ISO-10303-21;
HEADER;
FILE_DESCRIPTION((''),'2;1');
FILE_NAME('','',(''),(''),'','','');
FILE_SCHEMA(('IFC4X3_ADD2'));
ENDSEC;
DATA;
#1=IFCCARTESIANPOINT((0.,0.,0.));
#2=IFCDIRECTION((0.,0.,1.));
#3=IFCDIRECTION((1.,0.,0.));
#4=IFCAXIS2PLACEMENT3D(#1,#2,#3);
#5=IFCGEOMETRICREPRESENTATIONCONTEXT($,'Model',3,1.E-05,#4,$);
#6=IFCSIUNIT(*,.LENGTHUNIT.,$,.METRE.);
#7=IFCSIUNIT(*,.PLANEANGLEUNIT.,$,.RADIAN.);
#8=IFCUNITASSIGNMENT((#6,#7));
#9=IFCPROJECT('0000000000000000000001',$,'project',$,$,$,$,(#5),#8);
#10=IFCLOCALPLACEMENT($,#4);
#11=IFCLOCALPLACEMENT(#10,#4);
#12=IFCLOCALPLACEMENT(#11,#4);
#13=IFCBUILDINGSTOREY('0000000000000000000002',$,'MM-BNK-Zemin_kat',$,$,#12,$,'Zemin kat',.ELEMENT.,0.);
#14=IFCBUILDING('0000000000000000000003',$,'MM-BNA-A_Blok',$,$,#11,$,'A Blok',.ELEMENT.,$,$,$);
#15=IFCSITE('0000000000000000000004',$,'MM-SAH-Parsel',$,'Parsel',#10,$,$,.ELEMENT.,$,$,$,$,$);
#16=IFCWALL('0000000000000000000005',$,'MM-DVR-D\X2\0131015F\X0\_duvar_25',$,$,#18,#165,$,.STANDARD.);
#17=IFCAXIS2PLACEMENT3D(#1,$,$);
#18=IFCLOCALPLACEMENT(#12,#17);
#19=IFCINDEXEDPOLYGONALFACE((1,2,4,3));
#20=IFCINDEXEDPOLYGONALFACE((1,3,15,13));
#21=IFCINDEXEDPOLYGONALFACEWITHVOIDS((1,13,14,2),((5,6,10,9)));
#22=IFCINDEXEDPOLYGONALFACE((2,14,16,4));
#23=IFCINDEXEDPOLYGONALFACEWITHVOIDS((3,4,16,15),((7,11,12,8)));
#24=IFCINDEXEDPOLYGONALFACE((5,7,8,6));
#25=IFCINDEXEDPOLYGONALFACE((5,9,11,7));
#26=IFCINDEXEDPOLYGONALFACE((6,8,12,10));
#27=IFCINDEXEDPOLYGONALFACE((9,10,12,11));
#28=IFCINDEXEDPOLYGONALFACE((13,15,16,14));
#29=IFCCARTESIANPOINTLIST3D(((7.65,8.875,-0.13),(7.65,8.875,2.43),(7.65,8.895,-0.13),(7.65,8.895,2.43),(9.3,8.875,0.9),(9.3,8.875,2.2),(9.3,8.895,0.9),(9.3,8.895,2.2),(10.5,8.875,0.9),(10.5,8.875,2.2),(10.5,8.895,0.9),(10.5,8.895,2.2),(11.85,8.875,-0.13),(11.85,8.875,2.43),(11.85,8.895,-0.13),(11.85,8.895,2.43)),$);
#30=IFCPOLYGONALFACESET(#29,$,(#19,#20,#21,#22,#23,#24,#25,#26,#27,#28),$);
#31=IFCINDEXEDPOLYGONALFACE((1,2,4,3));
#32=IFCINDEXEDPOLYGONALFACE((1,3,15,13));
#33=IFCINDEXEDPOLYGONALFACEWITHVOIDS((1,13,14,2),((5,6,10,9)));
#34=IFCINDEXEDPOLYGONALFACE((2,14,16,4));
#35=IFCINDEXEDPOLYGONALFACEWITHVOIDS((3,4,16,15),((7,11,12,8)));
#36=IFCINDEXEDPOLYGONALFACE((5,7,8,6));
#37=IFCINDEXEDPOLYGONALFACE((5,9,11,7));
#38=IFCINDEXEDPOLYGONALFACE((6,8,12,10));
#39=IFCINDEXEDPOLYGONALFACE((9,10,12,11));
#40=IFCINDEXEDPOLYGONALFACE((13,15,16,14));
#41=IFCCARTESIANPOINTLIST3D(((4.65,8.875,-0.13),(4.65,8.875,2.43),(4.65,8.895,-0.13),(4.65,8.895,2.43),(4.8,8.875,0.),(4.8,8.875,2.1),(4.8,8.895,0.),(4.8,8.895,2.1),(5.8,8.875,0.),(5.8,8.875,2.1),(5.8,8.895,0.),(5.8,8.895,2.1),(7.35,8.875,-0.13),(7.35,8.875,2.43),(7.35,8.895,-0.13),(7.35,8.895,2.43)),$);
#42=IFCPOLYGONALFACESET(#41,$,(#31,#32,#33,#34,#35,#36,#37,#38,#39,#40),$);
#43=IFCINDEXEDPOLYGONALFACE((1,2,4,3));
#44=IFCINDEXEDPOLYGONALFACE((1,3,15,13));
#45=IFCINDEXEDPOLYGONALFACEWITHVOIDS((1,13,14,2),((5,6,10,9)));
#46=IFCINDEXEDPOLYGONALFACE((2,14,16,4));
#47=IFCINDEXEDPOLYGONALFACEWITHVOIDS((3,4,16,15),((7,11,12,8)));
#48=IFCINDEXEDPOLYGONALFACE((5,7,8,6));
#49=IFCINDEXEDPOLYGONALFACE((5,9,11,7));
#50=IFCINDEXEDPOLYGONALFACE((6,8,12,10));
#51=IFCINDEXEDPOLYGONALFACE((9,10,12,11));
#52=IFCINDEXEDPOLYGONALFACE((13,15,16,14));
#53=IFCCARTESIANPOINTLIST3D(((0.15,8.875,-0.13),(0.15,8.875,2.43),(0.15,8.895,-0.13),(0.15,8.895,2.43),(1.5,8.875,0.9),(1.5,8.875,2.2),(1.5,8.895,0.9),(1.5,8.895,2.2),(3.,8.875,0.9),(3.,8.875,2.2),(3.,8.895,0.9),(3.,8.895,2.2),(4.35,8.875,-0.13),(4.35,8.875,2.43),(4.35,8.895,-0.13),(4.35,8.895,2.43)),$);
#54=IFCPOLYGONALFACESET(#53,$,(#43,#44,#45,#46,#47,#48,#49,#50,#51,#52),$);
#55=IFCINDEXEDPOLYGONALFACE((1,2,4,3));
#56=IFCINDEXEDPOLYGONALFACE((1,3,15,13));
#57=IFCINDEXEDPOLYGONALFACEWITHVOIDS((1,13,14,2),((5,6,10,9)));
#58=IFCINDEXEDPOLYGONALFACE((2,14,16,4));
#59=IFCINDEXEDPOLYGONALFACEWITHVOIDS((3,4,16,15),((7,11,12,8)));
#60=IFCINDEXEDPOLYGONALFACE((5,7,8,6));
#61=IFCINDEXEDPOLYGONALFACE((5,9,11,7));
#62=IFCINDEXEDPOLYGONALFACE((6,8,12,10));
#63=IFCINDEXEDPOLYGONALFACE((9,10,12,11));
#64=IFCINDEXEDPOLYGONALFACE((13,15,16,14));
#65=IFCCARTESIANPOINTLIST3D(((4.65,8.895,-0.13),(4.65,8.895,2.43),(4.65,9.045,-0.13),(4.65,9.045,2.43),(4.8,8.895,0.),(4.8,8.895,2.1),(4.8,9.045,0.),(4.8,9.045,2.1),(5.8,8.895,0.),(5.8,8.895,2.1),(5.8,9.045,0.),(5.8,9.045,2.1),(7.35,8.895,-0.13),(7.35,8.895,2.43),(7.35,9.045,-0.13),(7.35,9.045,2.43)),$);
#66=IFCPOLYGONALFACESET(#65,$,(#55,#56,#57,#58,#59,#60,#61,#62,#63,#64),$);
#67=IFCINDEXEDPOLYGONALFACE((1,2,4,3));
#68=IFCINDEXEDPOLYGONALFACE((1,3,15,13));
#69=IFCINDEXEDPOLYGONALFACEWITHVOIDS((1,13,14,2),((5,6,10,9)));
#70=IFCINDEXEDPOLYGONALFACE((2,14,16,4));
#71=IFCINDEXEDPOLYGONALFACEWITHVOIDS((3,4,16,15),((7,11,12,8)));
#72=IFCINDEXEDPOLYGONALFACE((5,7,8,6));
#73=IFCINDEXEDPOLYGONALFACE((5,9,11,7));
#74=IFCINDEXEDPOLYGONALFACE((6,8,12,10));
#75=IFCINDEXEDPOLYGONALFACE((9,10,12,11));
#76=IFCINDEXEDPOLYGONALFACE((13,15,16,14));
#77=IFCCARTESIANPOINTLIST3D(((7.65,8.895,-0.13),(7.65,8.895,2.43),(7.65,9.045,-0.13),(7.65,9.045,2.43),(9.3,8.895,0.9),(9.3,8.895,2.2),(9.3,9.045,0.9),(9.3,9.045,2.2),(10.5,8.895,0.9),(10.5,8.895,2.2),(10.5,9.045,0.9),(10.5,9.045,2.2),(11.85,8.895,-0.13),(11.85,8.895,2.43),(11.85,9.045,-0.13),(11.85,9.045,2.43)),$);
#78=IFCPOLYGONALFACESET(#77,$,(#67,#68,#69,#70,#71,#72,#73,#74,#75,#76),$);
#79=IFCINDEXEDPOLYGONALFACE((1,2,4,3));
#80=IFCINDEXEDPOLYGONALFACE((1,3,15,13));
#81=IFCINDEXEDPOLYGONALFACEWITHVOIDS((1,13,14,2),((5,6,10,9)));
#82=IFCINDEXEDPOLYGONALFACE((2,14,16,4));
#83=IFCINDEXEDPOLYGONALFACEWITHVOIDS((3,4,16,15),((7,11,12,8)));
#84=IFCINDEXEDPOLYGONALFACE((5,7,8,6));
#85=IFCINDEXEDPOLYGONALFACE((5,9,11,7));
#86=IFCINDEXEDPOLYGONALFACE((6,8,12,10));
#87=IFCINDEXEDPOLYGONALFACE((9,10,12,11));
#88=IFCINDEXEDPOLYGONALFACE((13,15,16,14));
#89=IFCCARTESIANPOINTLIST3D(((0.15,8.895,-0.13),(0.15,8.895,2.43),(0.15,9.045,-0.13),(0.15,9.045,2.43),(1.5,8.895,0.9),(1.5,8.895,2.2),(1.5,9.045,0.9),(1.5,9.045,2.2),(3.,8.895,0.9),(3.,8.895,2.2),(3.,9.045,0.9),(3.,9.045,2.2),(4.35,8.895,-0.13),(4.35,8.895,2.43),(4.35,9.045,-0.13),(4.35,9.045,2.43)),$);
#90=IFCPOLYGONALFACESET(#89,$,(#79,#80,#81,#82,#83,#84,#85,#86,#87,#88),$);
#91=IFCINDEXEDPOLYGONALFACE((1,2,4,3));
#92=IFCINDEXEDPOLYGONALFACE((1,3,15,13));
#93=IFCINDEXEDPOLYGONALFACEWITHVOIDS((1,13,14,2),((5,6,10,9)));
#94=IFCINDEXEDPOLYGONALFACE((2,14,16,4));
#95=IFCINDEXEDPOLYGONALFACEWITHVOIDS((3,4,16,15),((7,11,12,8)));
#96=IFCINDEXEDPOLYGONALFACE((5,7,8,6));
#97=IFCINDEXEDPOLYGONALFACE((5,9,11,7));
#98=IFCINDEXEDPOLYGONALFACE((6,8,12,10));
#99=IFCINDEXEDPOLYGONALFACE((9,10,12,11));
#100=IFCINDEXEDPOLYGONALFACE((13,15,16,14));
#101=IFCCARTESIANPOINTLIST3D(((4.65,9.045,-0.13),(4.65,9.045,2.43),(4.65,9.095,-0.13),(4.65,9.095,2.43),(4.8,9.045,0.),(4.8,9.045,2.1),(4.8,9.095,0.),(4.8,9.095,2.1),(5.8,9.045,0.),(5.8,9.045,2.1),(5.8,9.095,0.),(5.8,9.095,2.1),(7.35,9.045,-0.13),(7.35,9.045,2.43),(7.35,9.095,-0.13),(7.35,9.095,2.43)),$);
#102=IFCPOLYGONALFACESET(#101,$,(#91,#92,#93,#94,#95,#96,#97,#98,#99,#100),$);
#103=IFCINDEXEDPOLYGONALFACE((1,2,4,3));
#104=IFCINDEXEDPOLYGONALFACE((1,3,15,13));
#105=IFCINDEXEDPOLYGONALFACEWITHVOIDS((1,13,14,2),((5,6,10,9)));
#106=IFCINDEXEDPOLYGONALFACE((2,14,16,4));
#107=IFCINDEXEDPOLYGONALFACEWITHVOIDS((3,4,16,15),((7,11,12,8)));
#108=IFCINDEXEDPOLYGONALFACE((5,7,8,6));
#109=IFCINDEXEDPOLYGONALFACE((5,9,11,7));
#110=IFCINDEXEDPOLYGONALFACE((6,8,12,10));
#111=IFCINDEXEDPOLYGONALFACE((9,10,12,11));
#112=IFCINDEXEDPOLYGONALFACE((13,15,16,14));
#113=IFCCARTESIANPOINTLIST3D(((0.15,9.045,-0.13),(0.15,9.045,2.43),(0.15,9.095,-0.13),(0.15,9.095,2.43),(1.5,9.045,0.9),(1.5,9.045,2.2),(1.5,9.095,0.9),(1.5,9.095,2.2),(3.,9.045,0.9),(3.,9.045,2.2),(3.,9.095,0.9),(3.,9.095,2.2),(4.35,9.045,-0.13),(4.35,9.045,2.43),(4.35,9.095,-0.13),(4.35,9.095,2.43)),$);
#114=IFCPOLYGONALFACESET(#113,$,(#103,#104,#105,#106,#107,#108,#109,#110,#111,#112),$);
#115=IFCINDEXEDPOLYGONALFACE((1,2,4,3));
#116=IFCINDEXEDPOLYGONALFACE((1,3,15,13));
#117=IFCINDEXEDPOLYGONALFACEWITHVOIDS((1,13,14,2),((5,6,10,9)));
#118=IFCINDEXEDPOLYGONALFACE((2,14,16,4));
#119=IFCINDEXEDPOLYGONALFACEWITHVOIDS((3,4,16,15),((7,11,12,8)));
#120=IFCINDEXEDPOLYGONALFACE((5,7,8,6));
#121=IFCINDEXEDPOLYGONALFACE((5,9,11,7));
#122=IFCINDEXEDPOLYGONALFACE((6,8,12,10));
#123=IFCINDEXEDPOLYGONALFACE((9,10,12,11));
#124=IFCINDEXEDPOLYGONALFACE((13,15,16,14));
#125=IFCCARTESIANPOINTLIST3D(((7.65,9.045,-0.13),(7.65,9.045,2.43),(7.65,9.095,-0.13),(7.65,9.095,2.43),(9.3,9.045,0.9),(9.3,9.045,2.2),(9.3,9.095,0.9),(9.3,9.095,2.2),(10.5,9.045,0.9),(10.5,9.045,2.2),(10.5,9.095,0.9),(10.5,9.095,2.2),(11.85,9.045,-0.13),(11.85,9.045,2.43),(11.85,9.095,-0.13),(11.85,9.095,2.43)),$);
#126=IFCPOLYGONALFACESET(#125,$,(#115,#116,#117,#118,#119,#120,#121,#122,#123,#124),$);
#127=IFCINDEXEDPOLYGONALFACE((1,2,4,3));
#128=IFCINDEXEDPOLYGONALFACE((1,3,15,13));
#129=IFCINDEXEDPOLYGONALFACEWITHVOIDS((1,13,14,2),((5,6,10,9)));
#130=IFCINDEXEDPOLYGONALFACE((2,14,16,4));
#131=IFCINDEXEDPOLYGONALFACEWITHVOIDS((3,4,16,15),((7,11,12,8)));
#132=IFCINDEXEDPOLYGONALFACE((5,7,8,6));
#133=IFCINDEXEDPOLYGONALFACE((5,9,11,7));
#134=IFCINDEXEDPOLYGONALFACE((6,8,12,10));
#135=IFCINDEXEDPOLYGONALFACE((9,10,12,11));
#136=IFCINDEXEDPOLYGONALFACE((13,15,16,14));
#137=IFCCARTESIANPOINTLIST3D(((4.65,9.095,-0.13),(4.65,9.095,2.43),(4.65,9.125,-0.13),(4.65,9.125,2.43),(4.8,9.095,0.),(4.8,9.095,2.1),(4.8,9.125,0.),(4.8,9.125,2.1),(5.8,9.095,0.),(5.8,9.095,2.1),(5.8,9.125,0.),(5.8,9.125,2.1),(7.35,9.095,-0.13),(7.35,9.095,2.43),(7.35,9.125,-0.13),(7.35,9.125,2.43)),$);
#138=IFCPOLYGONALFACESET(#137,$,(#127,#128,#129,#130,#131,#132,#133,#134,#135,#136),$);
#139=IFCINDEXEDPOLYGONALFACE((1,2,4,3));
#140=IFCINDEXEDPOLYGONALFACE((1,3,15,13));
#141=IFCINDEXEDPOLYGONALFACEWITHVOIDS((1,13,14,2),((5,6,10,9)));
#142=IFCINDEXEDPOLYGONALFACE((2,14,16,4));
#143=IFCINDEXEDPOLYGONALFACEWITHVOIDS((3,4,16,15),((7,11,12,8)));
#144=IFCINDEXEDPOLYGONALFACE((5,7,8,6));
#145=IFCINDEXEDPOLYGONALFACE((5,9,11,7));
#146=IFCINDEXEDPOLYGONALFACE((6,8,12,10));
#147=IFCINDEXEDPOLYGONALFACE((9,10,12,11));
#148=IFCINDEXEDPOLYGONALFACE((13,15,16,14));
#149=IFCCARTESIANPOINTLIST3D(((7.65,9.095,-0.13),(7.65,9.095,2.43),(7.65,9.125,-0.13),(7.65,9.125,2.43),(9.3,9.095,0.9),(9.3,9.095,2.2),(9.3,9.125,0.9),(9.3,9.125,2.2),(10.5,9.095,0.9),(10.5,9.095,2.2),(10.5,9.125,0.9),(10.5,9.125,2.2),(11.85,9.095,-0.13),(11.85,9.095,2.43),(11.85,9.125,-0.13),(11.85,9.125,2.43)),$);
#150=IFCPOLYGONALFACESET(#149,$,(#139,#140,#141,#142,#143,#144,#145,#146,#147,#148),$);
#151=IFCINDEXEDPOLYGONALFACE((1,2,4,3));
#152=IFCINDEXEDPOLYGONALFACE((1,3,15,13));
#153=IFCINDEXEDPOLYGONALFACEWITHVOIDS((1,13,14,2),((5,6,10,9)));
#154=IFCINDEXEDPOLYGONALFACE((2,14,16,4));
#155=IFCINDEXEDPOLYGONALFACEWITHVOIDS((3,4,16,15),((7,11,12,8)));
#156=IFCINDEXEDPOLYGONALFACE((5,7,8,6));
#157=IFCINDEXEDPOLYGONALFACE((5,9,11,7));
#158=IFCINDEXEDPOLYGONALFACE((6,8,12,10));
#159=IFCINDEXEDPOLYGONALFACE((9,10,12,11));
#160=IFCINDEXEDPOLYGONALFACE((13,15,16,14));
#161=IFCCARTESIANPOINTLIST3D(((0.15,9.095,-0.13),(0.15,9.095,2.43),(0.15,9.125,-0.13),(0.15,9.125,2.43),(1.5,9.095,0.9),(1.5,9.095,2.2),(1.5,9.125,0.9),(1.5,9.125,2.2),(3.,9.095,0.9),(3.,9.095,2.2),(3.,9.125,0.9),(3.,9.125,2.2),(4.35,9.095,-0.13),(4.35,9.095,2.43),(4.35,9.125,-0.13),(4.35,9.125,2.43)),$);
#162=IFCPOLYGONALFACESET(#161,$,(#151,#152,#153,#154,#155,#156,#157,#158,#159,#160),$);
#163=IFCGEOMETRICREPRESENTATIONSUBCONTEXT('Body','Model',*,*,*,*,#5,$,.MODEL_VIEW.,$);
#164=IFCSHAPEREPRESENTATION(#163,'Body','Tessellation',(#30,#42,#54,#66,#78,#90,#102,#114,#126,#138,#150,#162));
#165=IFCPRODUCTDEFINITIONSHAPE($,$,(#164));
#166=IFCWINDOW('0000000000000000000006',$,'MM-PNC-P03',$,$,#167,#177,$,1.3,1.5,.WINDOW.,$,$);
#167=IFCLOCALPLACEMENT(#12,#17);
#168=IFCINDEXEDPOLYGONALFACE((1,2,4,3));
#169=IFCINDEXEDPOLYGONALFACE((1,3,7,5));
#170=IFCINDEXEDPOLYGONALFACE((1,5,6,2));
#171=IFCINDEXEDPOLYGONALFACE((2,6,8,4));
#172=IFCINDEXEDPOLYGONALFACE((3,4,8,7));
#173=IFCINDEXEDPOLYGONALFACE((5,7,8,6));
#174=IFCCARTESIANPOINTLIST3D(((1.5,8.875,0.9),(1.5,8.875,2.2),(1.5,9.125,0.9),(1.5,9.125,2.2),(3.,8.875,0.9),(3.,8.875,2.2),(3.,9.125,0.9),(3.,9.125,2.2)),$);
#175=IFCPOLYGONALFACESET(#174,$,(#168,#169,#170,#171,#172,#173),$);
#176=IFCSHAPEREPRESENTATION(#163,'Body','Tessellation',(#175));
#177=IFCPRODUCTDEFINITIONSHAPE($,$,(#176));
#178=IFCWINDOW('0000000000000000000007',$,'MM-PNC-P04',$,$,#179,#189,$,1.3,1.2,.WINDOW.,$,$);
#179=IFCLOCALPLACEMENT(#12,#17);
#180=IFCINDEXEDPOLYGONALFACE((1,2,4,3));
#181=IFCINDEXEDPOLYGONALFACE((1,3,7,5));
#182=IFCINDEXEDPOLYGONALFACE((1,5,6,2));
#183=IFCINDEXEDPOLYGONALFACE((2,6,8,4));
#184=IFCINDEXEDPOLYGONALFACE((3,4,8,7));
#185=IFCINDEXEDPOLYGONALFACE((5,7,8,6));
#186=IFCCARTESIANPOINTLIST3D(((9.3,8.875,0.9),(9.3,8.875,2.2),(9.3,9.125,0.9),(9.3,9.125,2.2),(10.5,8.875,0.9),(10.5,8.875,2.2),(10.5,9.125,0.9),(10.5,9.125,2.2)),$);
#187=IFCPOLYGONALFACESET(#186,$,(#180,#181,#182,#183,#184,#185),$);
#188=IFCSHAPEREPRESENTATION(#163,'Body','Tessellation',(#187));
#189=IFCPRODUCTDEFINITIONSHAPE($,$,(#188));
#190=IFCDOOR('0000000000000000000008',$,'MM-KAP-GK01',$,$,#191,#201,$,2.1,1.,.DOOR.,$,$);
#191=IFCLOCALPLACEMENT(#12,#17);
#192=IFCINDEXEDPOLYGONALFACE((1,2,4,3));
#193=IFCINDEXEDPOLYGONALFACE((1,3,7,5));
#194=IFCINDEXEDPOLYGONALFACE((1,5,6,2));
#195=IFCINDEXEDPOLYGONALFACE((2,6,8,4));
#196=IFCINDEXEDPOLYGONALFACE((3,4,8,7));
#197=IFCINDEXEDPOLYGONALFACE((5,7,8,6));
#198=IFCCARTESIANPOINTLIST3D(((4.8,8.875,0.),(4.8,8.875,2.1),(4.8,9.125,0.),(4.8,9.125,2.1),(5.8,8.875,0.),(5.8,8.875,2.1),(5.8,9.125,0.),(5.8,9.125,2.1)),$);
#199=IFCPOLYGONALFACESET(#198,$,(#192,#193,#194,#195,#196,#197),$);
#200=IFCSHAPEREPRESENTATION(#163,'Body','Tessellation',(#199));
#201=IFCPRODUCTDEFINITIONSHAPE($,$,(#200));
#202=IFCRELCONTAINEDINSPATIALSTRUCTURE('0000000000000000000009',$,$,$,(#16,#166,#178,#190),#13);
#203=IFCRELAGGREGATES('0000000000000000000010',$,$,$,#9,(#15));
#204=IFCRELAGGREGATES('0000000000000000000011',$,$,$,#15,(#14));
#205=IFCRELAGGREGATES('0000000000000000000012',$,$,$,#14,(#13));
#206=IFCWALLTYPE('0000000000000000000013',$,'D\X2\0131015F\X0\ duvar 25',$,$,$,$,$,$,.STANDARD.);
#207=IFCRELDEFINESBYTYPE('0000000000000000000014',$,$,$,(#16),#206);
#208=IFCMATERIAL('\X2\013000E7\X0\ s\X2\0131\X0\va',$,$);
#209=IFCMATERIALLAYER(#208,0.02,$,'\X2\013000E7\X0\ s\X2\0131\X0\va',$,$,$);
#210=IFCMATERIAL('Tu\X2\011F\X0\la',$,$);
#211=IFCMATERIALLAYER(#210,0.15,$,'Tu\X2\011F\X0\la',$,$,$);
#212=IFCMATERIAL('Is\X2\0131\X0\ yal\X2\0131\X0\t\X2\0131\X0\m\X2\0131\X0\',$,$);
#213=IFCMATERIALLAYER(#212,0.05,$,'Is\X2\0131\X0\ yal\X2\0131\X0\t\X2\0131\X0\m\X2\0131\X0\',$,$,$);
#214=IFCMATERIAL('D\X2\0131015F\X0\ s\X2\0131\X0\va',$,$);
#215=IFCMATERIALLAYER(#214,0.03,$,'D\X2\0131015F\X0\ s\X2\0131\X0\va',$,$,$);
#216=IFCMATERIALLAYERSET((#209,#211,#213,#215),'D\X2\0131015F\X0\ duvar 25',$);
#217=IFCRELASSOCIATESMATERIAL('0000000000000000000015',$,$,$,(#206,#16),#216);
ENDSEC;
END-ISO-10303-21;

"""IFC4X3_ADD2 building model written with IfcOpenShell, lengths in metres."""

from ifc_helpers import new_model, si_unit, frame, origin, origin_with_axes, place, context, subcontext, project, spatial, polyline, outline, extrude, material, layer, layer_set, type_object, element, fill, save


model = new_model("IFC4X3_ADD2")

# Units and contexts
model_context = context("Model", 3, precision=1e-05, world=origin_with_axes())
body_context = subcontext(model_context, "Body", "Model", "MODEL_VIEW")
ifc_project = project(units=[si_unit("LENGTHUNIT", "METRE"), si_unit("PLANEANGLEUNIT", "RADIAN")], contexts=[model_context])

# Site, building, storey
site_placement = place(None, origin_with_axes())
site = spatial("IfcSite", under=ifc_project, at=site_placement, Name="MM-SAH-Parsel", ObjectType="Parsel", CompositionType="ELEMENT")
building_placement = place(site_placement, origin_with_axes())
building = spatial("IfcBuilding", under=site, at=building_placement, Name="MM-BNA-A_Blok", LongName="A Blok", CompositionType="ELEMENT")
storey_placement = place(building_placement, origin_with_axes())
storey = spatial("IfcBuildingStorey", under=building, at=storey_placement, Name="MM-BNK-Zemin_kat", LongName="Zemin kat", CompositionType="ELEMENT", Elevation=0.0)

# Shared definitions
ifc_material_1 = material(Name="İç sıva")
ifc_layer_1 = layer(ifc_material_1, 0.02, Name="İç sıva")
ifc_material_2 = material(Name="Tuğla")
ifc_layer_2 = layer(ifc_material_2, 0.15, Name="Tuğla")
ifc_material_3 = material(Name="Isı yalıtımı")
ifc_layer_3 = layer(ifc_material_3, 0.05, Name="Isı yalıtımı")
ifc_material_4 = material(Name="Dış sıva")
ifc_layer_4 = layer(ifc_material_4, 0.03, Name="Dış sıva")
ifc_layer_set_1 = layer_set([ifc_layer_1, ifc_layer_2, ifc_layer_3, ifc_layer_4], Name="Dış duvar 25")
wall_type_1 = type_object("IfcWallType", Name="Dış duvar 25", PredefinedType="STANDARD", material=ifc_layer_set_1)

# Wall, openings, windows, door
wall_1_placement = place(storey_placement, origin_with_axes())
wall_1 = element("IfcWall", 1, at=wall_1_placement, inside=storey, type_object=wall_type_1, material=ifc_layer_set_1, Name="MM-DVR-Dış_duvar_25", PredefinedType="STANDARD", context=body_context, shape_type="SweptSolid", body=[
    extrude(outline(polyline([(11.85, 8.895), (7.65, 8.895), (7.65, 8.875), (11.85, 8.875), (11.85, 8.895)])), frame((0.0, 0.0, -0.13)), (0.0, 0.0, 1.0), 2.56),
    extrude(outline(polyline([(7.35, 8.895), (4.65, 8.895), (4.65, 8.875), (7.35, 8.875), (7.35, 8.895)])), frame((0.0, 0.0, -0.13)), (0.0, 0.0, 1.0), 2.56),
    extrude(outline(polyline([(4.35, 8.895), (0.15, 8.895), (0.15, 8.875), (4.35, 8.875), (4.35, 8.895)])), frame((0.0, 0.0, -0.13)), (0.0, 0.0, 1.0), 2.56),
    extrude(outline(polyline([(7.35, 9.045), (4.65, 9.045), (4.65, 8.895), (7.35, 8.895), (7.35, 9.045)])), frame((0.0, 0.0, -0.13)), (0.0, 0.0, 1.0), 2.56),
    extrude(outline(polyline([(11.85, 9.045), (7.65, 9.045), (7.65, 8.895), (11.85, 8.895), (11.85, 9.045)])), frame((0.0, 0.0, -0.13)), (0.0, 0.0, 1.0), 2.56),
    extrude(outline(polyline([(4.35, 9.045), (0.15, 9.045), (0.15, 8.895), (4.35, 8.895), (4.35, 9.045)])), frame((0.0, 0.0, -0.13)), (0.0, 0.0, 1.0), 2.56),
    extrude(outline(polyline([(7.35, 9.095), (4.65, 9.095), (4.65, 9.045), (7.35, 9.045), (7.35, 9.095)])), frame((0.0, 0.0, -0.13)), (0.0, 0.0, 1.0), 2.56),
    extrude(outline(polyline([(4.35, 9.095), (0.15, 9.095), (0.15, 9.045), (4.35, 9.045), (4.35, 9.095)])), frame((0.0, 0.0, -0.13)), (0.0, 0.0, 1.0), 2.56),
    extrude(outline(polyline([(11.85, 9.095), (7.65, 9.095), (7.65, 9.045), (11.85, 9.045), (11.85, 9.095)])), frame((0.0, 0.0, -0.13)), (0.0, 0.0, 1.0), 2.56),
    extrude(outline(polyline([(7.35, 9.125), (4.65, 9.125), (4.65, 9.095), (7.35, 9.095), (7.35, 9.125)])), frame((0.0, 0.0, -0.13)), (0.0, 0.0, 1.0), 2.56),
    extrude(outline(polyline([(11.85, 9.125), (7.65, 9.125), (7.65, 9.095), (11.85, 9.095), (11.85, 9.125)])), frame((0.0, 0.0, -0.13)), (0.0, 0.0, 1.0), 2.56),
    extrude(outline(polyline([(4.35, 9.125), (0.15, 9.125), (0.15, 9.095), (4.35, 9.095), (4.35, 9.125)])), frame((0.0, 0.0, -0.13)), (0.0, 0.0, 1.0), 2.56),
])
opening_1_placement = place(storey_placement, origin_with_axes())
opening_1 = element("IfcOpeningElement", 2, at=opening_1_placement, cuts=wall_1, PredefinedType="OPENING", context=body_context, shape_type="SweptSolid", body=[
    extrude(outline(polyline([(3.0, 8.875), (1.5, 8.875), (1.5, 9.125), (3.0, 9.125), (3.0, 8.875)])), frame((0.0, 0.0, 0.9)), (0.0, 0.0, 1.0), 1.3),
])
opening_2_placement = place(storey_placement, origin_with_axes())
opening_2 = element("IfcOpeningElement", 3, at=opening_2_placement, cuts=wall_1, PredefinedType="OPENING", context=body_context, shape_type="SweptSolid", body=[
    extrude(outline(polyline([(10.5, 8.875), (9.3, 8.875), (9.3, 9.125), (10.5, 9.125), (10.5, 8.875)])), frame((0.0, 0.0, 0.9)), (0.0, 0.0, 1.0), 1.3),
])
opening_3_placement = place(storey_placement, origin_with_axes())
opening_3 = element("IfcOpeningElement", 4, at=opening_3_placement, cuts=wall_1, PredefinedType="OPENING", context=body_context, shape_type="SweptSolid", body=[
    extrude(outline(polyline([(5.8, 8.875), (4.8, 8.875), (4.8, 9.125), (5.8, 9.125), (5.8, 8.875)])), origin(), (0.0, 0.0, 1.0), 2.1),
])
window_1_placement = place(storey_placement, origin_with_axes())
window_1 = element("IfcWindow", 5, at=window_1_placement, inside=storey, Name="MM-PNC-P03", OverallHeight=1.3, OverallWidth=1.5, PredefinedType="WINDOW", context=body_context, shape_type="SweptSolid", body=[
    extrude(outline(polyline([(3.0, 8.875), (1.5, 8.875), (1.5, 9.125), (3.0, 9.125), (3.0, 8.875)])), frame((0.0, 0.0, 0.9)), (0.0, 0.0, 1.0), 1.3),
])
fill(opening_1, window_1)
window_2_placement = place(storey_placement, origin_with_axes())
window_2 = element("IfcWindow", 6, at=window_2_placement, inside=storey, Name="MM-PNC-P04", OverallHeight=1.3, OverallWidth=1.2, PredefinedType="WINDOW", context=body_context, shape_type="SweptSolid", body=[
    extrude(outline(polyline([(10.5, 8.875), (9.3, 8.875), (9.3, 9.125), (10.5, 9.125), (10.5, 8.875)])), frame((0.0, 0.0, 0.9)), (0.0, 0.0, 1.0), 1.3),
])
fill(opening_2, window_2)
door_1_placement = place(storey_placement, origin_with_axes())
door_1 = element("IfcDoor", 7, at=door_1_placement, inside=storey, Name="MM-KAP-GK01", OverallHeight=2.1, OverallWidth=1.0, PredefinedType="DOOR", context=body_context, shape_type="SweptSolid", body=[
    extrude(outline(polyline([(5.8, 8.875), (4.8, 8.875), (4.8, 9.125), (5.8, 9.125), (5.8, 8.875)])), origin(), (0.0, 0.0, 1.0), 2.1),
])
fill(opening_3, door_1)

save(model, "model.ifc")
